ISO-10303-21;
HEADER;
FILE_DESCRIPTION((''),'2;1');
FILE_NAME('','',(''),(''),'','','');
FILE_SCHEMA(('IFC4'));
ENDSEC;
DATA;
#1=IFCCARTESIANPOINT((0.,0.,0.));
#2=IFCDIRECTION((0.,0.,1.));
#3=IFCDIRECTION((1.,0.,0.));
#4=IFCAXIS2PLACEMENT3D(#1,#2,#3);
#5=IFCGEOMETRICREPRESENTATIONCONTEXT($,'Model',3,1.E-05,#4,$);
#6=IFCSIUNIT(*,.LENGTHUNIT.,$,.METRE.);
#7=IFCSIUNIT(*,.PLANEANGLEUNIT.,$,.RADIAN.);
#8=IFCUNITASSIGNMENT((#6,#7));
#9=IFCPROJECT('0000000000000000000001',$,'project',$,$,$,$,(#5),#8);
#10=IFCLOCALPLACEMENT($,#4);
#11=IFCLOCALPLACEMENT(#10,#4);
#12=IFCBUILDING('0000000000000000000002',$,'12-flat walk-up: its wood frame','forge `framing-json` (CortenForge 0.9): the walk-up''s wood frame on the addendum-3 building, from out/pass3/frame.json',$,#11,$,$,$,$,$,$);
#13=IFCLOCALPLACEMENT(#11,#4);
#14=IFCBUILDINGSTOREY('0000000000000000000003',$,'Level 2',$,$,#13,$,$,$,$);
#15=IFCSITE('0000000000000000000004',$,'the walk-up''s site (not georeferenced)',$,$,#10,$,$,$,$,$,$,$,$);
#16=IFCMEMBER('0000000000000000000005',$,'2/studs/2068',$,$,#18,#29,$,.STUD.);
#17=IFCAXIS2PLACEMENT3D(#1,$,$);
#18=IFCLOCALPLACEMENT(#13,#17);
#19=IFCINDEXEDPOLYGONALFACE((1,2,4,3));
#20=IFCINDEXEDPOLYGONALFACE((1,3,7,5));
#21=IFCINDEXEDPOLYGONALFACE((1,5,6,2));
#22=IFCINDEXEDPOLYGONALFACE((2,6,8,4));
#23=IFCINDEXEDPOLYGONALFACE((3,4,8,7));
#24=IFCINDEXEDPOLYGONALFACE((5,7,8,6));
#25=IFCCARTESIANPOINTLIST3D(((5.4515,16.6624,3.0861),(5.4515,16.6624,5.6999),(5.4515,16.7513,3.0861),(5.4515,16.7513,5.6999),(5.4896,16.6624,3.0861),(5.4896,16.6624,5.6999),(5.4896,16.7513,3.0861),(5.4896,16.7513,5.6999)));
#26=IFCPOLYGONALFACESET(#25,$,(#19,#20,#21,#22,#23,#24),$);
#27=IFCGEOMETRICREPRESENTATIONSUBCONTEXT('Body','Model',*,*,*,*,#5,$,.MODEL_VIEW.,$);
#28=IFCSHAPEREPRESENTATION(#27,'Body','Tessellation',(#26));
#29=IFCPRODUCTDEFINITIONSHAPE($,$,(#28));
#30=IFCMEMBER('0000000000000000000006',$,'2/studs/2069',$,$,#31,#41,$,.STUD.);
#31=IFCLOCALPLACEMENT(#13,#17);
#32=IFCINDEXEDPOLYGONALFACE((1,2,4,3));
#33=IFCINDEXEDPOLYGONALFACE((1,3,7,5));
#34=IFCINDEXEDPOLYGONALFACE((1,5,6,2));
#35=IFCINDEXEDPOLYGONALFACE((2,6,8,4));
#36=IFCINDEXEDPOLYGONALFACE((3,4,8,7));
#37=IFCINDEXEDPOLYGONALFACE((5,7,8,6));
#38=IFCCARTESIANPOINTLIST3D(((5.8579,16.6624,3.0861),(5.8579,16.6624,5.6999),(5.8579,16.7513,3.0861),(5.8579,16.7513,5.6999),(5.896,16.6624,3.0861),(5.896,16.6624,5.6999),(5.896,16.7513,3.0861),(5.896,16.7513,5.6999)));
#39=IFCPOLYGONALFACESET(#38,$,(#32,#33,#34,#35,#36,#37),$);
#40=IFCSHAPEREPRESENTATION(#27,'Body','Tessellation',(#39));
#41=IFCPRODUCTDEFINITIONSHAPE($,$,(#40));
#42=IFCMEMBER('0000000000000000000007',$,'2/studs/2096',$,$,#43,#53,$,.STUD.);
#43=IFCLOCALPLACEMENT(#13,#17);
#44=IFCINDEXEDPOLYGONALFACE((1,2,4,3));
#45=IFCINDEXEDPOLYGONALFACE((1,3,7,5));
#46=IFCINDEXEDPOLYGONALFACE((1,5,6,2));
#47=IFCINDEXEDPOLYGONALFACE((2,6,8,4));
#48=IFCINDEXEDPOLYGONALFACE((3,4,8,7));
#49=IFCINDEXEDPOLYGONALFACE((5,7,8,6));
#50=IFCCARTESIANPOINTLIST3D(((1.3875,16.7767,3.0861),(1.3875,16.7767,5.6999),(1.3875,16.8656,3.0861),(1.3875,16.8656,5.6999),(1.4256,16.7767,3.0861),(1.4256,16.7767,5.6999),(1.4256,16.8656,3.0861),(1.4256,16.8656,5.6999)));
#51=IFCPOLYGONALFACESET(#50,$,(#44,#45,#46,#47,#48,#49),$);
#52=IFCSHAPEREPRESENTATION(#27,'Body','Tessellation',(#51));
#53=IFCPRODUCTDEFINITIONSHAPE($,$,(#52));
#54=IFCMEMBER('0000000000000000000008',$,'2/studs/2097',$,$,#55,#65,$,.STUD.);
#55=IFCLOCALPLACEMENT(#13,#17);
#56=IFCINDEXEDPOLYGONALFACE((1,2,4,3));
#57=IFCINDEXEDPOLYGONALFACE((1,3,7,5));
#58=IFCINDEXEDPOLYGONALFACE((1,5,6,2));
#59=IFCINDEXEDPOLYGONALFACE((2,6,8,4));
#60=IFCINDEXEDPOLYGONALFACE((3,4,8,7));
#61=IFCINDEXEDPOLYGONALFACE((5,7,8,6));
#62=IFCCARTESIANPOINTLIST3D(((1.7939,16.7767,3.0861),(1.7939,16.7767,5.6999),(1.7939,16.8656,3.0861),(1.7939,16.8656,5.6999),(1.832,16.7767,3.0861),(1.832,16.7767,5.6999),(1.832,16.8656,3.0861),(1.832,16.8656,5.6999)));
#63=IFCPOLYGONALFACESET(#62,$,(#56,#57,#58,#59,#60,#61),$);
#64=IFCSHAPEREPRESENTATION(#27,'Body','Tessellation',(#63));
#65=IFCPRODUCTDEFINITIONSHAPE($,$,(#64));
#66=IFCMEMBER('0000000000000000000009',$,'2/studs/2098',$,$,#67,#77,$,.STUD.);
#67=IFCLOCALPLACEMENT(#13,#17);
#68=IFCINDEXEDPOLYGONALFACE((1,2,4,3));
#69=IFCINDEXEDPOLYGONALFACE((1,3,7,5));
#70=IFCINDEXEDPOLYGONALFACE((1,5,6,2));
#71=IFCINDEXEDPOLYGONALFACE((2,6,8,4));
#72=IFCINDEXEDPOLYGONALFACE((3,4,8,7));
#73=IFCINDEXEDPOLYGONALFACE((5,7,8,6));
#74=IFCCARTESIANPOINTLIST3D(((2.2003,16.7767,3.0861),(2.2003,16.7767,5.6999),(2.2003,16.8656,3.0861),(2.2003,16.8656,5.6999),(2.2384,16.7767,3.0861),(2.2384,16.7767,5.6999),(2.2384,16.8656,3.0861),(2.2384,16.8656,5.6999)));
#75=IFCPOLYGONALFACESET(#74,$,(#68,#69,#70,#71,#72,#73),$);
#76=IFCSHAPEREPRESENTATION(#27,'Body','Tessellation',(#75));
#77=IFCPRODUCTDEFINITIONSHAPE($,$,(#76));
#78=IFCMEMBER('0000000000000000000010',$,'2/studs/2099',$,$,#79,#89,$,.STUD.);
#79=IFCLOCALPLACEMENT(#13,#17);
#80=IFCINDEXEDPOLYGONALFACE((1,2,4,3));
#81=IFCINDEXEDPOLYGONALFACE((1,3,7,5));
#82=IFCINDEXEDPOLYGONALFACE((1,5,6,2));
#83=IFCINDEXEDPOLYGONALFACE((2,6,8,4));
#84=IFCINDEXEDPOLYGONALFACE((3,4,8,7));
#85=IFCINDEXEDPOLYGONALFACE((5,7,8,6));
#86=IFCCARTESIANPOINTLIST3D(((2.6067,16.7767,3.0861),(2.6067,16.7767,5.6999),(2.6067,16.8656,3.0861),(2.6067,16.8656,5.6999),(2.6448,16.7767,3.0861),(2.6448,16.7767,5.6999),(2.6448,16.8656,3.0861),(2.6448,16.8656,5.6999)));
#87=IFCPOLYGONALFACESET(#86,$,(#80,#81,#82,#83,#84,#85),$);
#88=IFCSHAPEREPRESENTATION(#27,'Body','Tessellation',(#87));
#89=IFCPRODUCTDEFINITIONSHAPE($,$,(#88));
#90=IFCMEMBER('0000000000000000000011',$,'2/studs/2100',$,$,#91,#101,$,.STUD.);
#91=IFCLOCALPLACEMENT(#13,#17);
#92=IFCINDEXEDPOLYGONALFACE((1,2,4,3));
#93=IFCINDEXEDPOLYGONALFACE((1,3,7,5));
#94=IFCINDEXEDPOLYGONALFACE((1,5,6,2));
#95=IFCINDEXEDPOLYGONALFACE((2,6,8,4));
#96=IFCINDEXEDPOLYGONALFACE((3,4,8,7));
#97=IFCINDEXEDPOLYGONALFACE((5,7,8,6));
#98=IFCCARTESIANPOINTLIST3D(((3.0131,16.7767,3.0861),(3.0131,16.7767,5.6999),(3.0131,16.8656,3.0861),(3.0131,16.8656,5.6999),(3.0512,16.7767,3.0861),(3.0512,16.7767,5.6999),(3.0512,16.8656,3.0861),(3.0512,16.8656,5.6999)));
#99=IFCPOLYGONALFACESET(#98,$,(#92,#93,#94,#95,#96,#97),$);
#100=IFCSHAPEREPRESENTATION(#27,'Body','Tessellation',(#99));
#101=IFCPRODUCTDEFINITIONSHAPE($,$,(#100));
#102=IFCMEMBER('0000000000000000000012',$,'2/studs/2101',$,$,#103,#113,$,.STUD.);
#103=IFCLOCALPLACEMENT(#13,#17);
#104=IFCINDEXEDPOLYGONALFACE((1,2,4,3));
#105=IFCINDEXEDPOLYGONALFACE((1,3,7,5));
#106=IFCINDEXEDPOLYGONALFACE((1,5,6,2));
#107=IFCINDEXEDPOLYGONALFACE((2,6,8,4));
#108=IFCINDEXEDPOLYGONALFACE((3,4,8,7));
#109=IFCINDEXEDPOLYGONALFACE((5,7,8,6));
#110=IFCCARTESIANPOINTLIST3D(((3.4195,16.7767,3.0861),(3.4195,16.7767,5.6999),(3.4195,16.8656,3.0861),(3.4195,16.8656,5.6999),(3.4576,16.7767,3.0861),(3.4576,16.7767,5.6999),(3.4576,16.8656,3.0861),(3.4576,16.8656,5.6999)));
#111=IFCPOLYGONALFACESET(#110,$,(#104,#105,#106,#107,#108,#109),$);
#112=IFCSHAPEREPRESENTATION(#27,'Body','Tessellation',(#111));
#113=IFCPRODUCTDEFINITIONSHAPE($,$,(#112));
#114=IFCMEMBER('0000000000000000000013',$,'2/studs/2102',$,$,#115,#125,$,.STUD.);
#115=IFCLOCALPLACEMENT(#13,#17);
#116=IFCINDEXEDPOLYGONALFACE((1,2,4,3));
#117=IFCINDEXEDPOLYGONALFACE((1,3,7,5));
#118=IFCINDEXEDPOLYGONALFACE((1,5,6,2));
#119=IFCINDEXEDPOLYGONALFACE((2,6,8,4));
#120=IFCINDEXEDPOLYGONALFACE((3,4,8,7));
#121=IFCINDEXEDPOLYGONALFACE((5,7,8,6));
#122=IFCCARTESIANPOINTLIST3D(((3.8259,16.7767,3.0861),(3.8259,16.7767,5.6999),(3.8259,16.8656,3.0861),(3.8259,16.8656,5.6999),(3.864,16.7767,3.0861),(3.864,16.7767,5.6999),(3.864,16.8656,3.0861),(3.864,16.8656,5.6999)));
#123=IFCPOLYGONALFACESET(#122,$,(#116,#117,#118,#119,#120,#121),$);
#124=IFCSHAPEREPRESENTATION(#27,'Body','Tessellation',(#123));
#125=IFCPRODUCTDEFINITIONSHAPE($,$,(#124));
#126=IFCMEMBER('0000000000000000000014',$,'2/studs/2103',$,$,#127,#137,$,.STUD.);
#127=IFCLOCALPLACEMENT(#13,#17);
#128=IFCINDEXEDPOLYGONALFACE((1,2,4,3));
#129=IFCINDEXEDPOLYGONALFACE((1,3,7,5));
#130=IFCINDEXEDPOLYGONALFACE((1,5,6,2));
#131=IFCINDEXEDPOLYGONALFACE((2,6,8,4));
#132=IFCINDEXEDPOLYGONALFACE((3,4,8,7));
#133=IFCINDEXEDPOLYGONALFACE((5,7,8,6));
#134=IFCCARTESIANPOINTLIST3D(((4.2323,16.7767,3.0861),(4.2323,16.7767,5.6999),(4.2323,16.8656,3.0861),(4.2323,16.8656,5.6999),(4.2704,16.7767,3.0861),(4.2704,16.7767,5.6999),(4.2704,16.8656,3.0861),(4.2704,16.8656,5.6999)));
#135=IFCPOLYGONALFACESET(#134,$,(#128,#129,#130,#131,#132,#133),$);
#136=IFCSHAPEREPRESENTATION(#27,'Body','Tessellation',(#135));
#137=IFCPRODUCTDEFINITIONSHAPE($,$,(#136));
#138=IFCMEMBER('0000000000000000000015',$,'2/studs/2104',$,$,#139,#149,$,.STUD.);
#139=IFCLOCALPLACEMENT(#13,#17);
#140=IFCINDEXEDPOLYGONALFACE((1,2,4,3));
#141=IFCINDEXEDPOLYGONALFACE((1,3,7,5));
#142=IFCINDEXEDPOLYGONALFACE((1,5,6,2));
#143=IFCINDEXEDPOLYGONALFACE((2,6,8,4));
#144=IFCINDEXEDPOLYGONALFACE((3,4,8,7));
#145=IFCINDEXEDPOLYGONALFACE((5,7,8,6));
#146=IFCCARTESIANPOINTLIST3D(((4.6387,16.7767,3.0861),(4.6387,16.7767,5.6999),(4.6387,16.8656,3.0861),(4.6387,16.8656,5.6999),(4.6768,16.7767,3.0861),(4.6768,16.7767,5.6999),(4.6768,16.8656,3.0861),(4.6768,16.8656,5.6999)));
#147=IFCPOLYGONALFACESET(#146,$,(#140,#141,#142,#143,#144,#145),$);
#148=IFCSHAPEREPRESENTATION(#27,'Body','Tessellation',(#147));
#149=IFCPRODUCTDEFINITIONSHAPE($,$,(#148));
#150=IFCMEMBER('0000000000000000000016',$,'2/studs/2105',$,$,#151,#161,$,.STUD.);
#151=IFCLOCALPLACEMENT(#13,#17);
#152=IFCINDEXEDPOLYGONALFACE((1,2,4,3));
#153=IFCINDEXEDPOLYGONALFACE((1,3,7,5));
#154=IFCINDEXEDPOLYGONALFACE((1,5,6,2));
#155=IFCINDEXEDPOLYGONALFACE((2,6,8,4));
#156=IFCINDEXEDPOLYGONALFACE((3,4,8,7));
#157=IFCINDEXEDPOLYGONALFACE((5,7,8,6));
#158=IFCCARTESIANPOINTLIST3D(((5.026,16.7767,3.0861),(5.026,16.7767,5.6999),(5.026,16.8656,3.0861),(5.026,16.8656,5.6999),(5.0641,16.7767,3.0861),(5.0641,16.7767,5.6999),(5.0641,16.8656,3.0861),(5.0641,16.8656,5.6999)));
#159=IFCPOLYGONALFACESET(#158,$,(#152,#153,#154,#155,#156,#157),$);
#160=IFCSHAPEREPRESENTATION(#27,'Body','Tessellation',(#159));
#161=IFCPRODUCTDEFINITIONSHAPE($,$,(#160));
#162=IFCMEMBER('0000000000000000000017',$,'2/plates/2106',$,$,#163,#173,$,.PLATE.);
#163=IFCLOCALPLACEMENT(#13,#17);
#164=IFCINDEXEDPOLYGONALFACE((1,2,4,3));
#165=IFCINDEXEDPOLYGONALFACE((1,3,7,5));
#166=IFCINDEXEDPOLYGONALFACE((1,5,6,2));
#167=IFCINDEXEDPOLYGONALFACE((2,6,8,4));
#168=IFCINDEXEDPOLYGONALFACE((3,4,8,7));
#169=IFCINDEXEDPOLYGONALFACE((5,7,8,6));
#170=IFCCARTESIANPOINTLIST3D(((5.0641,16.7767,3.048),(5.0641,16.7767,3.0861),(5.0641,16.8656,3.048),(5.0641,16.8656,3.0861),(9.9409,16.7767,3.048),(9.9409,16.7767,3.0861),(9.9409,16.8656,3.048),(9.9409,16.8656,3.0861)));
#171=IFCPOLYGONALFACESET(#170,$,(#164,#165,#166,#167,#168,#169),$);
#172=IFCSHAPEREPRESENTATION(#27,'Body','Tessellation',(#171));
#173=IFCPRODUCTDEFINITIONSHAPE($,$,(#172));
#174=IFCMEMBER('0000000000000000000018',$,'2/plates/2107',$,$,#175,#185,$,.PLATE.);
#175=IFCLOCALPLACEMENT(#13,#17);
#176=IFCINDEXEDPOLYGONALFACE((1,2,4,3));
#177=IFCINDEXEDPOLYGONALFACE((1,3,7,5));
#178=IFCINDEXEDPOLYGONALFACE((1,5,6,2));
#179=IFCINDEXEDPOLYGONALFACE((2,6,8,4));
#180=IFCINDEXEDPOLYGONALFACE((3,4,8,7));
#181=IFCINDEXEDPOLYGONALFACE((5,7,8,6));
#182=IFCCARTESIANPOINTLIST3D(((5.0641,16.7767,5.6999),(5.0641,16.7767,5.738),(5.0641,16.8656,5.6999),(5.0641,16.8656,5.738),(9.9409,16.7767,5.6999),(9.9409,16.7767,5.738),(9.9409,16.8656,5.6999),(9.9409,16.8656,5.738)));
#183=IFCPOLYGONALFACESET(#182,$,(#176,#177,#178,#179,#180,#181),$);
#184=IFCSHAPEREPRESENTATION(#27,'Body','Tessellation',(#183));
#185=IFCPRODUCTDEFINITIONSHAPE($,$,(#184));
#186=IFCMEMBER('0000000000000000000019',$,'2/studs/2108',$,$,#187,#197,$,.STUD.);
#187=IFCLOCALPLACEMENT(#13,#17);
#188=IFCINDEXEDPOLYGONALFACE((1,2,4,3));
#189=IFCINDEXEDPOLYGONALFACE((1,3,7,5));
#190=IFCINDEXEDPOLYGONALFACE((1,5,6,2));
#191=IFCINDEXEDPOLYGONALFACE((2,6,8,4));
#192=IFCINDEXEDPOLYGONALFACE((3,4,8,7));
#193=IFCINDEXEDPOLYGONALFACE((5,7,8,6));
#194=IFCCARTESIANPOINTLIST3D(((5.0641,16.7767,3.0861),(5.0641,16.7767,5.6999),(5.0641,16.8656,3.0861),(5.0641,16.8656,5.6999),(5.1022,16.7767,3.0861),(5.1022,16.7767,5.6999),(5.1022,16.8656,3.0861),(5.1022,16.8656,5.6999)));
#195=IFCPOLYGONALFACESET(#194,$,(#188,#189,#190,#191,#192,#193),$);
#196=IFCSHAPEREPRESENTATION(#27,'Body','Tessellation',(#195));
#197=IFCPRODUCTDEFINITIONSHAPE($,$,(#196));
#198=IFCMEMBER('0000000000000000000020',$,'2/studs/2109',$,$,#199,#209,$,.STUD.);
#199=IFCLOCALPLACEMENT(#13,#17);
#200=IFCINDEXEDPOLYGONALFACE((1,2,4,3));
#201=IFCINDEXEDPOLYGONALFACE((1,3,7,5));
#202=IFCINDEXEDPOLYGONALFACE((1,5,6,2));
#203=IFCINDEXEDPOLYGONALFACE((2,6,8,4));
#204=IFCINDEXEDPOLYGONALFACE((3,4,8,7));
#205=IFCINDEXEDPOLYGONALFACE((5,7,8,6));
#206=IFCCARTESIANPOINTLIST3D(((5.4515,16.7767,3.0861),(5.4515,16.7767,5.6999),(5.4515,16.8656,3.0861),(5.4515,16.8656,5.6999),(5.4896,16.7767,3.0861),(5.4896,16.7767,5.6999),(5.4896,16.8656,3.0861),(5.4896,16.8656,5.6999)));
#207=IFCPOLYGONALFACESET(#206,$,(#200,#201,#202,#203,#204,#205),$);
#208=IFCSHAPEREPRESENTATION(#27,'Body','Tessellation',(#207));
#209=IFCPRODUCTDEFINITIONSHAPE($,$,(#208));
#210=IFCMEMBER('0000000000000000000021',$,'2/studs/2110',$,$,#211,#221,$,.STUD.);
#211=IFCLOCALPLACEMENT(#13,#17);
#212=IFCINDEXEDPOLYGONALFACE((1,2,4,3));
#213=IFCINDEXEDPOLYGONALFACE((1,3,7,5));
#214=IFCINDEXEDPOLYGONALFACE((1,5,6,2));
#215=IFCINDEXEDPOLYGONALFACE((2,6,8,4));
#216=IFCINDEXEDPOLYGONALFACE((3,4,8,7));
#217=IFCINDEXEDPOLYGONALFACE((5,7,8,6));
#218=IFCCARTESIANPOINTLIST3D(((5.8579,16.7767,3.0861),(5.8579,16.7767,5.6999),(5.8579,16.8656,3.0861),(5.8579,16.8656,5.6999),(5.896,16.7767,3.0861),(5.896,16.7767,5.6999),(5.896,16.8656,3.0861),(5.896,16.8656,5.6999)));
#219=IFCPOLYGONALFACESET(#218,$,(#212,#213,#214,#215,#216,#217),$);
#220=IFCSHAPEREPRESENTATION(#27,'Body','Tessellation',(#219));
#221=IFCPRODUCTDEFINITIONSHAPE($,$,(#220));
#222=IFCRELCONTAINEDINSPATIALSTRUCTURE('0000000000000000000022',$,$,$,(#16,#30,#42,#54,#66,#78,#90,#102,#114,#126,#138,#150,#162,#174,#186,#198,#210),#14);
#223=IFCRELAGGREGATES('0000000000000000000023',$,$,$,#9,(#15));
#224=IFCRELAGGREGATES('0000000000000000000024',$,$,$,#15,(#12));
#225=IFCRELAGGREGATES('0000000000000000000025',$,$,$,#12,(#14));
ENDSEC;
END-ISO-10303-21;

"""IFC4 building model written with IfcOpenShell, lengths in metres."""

from ifc_helpers import new_model, si_unit, frame, frame_2d, origin, origin_with_axes, place, context, subcontext, project, spatial, rectangle, extrude, element, save


model = new_model("IFC4")

# Units and contexts
model_context = context("Model", 3, precision=1e-05, world=origin_with_axes())
body_context = subcontext(model_context, "Body", "Model", "MODEL_VIEW")
ifc_project = project(units=[si_unit("LENGTHUNIT", "METRE"), si_unit("PLANEANGLEUNIT", "RADIAN")], contexts=[model_context])

# Site, building, storey
site_placement = place(None, origin_with_axes())
site = spatial("IfcSite", under=ifc_project, at=site_placement, Name="the walk-up's site (not georeferenced)")
building_placement = place(site_placement, origin_with_axes())
building = spatial("IfcBuilding", under=site, at=building_placement, Name="12-flat walk-up: its wood frame", Description="forge `framing-json` (CortenForge 0.9): the walk-up's wood frame on the addendum-3 building, from out/pass3/frame.json")
storey_placement = place(building_placement, origin_with_axes())
storey = spatial("IfcBuildingStorey", under=building, at=storey_placement, Name="Level 2")

# Members
for number, where, z_axis, x_axis, name in (
    (1, (5.4515, 16.6624, 3.0861), (0.0, 0.0, 1.0), (1.0, 0.0, 0.0), "2/studs/2068"),
    (2, (5.8579, 16.6624, 3.0861), (0.0, 0.0, 1.0), (1.0, 0.0, 0.0), "2/studs/2069"),
    (3, (1.3875, 16.7767, 3.0861), (0.0, 0.0, 1.0), (1.0, 0.0, 0.0), "2/studs/2096"),
):
    element("IfcMember", number, at=place(storey_placement, frame(where, z_axis=z_axis, x_axis=x_axis)), inside=storey, Name=name, PredefinedType="STUD", context=body_context, shape_type="SweptSolid", body=[
        extrude(rectangle(XDim=0.0381, YDim=0.0889, at=frame_2d((0.0191, 0.0444))), origin(), (0.0, 0.0, 1.0), 2.6138),
    ])
member_1_placement = place(storey_placement, frame((1.7939, 16.7767, 3.0861), z_axis=(0.0, 0.0, 1.0), x_axis=(1.0, 0.0, 0.0)))
element("IfcMember", 4, at=member_1_placement, inside=storey, Name="2/studs/2097", PredefinedType="STUD", context=body_context, shape_type="SweptSolid", body=[
    extrude(rectangle(XDim=0.0381, YDim=0.0889, at=frame_2d((0.019, 0.0444))), origin(), (0.0, 0.0, 1.0), 2.6138),
])
for number, where, z_axis, x_axis, name in (
    (5, (2.2003, 16.7767, 3.0861), (0.0, 0.0, 1.0), (1.0, 0.0, 0.0), "2/studs/2098"),
    (6, (2.6067, 16.7767, 3.0861), (0.0, 0.0, 1.0), (1.0, 0.0, 0.0), "2/studs/2099"),
    (7, (3.0131, 16.7767, 3.0861), (0.0, 0.0, 1.0), (1.0, 0.0, 0.0), "2/studs/2100"),
    (8, (3.4195, 16.7767, 3.0861), (0.0, 0.0, 1.0), (1.0, 0.0, 0.0), "2/studs/2101"),
    (9, (3.8259, 16.7767, 3.0861), (0.0, 0.0, 1.0), (1.0, 0.0, 0.0), "2/studs/2102"),
    (10, (4.2323, 16.7767, 3.0861), (0.0, 0.0, 1.0), (1.0, 0.0, 0.0), "2/studs/2103"),
    (11, (4.6387, 16.7767, 3.0861), (0.0, 0.0, 1.0), (1.0, 0.0, 0.0), "2/studs/2104"),
    (12, (5.026, 16.7767, 3.0861), (0.0, 0.0, 1.0), (1.0, 0.0, 0.0), "2/studs/2105"),
):
    element("IfcMember", number, at=place(storey_placement, frame(where, z_axis=z_axis, x_axis=x_axis)), inside=storey, Name=name, PredefinedType="STUD", context=body_context, shape_type="SweptSolid", body=[
        extrude(rectangle(XDim=0.0381, YDim=0.0889, at=frame_2d((0.0191, 0.0444))), origin(), (0.0, 0.0, 1.0), 2.6138),
    ])
for number, where, z_axis, x_axis, name in (
    (13, (5.0641, 16.7767, 3.048), (0.0, 0.0, 1.0), (1.0, 0.0, 0.0), "2/plates/2106"),
    (14, (5.0641, 16.7767, 5.6999), (0.0, 0.0, 1.0), (1.0, 0.0, 0.0), "2/plates/2107"),
):
    element("IfcMember", number, at=place(storey_placement, frame(where, z_axis=z_axis, x_axis=x_axis)), inside=storey, Name=name, PredefinedType="PLATE", context=body_context, shape_type="SweptSolid", body=[
        extrude(rectangle(XDim=4.8768, YDim=0.0889, at=frame_2d((2.4384, 0.0444))), origin(), (0.0, 0.0, 1.0), 0.0381),
    ])
for number, where, z_axis, x_axis, name in (
    (15, (5.0641, 16.7767, 3.0861), (0.0, 0.0, 1.0), (1.0, 0.0, 0.0), "2/studs/2108"),
    (16, (5.4515, 16.7767, 3.0861), (0.0, 0.0, 1.0), (1.0, 0.0, 0.0), "2/studs/2109"),
    (17, (5.8579, 16.7767, 3.0861), (0.0, 0.0, 1.0), (1.0, 0.0, 0.0), "2/studs/2110"),
):
    element("IfcMember", number, at=place(storey_placement, frame(where, z_axis=z_axis, x_axis=x_axis)), inside=storey, Name=name, PredefinedType="STUD", context=body_context, shape_type="SweptSolid", body=[
        extrude(rectangle(XDim=0.0381, YDim=0.0889, at=frame_2d((0.0191, 0.0444))), origin(), (0.0, 0.0, 1.0), 2.6138),
    ])

save(model, "model.ifc")
